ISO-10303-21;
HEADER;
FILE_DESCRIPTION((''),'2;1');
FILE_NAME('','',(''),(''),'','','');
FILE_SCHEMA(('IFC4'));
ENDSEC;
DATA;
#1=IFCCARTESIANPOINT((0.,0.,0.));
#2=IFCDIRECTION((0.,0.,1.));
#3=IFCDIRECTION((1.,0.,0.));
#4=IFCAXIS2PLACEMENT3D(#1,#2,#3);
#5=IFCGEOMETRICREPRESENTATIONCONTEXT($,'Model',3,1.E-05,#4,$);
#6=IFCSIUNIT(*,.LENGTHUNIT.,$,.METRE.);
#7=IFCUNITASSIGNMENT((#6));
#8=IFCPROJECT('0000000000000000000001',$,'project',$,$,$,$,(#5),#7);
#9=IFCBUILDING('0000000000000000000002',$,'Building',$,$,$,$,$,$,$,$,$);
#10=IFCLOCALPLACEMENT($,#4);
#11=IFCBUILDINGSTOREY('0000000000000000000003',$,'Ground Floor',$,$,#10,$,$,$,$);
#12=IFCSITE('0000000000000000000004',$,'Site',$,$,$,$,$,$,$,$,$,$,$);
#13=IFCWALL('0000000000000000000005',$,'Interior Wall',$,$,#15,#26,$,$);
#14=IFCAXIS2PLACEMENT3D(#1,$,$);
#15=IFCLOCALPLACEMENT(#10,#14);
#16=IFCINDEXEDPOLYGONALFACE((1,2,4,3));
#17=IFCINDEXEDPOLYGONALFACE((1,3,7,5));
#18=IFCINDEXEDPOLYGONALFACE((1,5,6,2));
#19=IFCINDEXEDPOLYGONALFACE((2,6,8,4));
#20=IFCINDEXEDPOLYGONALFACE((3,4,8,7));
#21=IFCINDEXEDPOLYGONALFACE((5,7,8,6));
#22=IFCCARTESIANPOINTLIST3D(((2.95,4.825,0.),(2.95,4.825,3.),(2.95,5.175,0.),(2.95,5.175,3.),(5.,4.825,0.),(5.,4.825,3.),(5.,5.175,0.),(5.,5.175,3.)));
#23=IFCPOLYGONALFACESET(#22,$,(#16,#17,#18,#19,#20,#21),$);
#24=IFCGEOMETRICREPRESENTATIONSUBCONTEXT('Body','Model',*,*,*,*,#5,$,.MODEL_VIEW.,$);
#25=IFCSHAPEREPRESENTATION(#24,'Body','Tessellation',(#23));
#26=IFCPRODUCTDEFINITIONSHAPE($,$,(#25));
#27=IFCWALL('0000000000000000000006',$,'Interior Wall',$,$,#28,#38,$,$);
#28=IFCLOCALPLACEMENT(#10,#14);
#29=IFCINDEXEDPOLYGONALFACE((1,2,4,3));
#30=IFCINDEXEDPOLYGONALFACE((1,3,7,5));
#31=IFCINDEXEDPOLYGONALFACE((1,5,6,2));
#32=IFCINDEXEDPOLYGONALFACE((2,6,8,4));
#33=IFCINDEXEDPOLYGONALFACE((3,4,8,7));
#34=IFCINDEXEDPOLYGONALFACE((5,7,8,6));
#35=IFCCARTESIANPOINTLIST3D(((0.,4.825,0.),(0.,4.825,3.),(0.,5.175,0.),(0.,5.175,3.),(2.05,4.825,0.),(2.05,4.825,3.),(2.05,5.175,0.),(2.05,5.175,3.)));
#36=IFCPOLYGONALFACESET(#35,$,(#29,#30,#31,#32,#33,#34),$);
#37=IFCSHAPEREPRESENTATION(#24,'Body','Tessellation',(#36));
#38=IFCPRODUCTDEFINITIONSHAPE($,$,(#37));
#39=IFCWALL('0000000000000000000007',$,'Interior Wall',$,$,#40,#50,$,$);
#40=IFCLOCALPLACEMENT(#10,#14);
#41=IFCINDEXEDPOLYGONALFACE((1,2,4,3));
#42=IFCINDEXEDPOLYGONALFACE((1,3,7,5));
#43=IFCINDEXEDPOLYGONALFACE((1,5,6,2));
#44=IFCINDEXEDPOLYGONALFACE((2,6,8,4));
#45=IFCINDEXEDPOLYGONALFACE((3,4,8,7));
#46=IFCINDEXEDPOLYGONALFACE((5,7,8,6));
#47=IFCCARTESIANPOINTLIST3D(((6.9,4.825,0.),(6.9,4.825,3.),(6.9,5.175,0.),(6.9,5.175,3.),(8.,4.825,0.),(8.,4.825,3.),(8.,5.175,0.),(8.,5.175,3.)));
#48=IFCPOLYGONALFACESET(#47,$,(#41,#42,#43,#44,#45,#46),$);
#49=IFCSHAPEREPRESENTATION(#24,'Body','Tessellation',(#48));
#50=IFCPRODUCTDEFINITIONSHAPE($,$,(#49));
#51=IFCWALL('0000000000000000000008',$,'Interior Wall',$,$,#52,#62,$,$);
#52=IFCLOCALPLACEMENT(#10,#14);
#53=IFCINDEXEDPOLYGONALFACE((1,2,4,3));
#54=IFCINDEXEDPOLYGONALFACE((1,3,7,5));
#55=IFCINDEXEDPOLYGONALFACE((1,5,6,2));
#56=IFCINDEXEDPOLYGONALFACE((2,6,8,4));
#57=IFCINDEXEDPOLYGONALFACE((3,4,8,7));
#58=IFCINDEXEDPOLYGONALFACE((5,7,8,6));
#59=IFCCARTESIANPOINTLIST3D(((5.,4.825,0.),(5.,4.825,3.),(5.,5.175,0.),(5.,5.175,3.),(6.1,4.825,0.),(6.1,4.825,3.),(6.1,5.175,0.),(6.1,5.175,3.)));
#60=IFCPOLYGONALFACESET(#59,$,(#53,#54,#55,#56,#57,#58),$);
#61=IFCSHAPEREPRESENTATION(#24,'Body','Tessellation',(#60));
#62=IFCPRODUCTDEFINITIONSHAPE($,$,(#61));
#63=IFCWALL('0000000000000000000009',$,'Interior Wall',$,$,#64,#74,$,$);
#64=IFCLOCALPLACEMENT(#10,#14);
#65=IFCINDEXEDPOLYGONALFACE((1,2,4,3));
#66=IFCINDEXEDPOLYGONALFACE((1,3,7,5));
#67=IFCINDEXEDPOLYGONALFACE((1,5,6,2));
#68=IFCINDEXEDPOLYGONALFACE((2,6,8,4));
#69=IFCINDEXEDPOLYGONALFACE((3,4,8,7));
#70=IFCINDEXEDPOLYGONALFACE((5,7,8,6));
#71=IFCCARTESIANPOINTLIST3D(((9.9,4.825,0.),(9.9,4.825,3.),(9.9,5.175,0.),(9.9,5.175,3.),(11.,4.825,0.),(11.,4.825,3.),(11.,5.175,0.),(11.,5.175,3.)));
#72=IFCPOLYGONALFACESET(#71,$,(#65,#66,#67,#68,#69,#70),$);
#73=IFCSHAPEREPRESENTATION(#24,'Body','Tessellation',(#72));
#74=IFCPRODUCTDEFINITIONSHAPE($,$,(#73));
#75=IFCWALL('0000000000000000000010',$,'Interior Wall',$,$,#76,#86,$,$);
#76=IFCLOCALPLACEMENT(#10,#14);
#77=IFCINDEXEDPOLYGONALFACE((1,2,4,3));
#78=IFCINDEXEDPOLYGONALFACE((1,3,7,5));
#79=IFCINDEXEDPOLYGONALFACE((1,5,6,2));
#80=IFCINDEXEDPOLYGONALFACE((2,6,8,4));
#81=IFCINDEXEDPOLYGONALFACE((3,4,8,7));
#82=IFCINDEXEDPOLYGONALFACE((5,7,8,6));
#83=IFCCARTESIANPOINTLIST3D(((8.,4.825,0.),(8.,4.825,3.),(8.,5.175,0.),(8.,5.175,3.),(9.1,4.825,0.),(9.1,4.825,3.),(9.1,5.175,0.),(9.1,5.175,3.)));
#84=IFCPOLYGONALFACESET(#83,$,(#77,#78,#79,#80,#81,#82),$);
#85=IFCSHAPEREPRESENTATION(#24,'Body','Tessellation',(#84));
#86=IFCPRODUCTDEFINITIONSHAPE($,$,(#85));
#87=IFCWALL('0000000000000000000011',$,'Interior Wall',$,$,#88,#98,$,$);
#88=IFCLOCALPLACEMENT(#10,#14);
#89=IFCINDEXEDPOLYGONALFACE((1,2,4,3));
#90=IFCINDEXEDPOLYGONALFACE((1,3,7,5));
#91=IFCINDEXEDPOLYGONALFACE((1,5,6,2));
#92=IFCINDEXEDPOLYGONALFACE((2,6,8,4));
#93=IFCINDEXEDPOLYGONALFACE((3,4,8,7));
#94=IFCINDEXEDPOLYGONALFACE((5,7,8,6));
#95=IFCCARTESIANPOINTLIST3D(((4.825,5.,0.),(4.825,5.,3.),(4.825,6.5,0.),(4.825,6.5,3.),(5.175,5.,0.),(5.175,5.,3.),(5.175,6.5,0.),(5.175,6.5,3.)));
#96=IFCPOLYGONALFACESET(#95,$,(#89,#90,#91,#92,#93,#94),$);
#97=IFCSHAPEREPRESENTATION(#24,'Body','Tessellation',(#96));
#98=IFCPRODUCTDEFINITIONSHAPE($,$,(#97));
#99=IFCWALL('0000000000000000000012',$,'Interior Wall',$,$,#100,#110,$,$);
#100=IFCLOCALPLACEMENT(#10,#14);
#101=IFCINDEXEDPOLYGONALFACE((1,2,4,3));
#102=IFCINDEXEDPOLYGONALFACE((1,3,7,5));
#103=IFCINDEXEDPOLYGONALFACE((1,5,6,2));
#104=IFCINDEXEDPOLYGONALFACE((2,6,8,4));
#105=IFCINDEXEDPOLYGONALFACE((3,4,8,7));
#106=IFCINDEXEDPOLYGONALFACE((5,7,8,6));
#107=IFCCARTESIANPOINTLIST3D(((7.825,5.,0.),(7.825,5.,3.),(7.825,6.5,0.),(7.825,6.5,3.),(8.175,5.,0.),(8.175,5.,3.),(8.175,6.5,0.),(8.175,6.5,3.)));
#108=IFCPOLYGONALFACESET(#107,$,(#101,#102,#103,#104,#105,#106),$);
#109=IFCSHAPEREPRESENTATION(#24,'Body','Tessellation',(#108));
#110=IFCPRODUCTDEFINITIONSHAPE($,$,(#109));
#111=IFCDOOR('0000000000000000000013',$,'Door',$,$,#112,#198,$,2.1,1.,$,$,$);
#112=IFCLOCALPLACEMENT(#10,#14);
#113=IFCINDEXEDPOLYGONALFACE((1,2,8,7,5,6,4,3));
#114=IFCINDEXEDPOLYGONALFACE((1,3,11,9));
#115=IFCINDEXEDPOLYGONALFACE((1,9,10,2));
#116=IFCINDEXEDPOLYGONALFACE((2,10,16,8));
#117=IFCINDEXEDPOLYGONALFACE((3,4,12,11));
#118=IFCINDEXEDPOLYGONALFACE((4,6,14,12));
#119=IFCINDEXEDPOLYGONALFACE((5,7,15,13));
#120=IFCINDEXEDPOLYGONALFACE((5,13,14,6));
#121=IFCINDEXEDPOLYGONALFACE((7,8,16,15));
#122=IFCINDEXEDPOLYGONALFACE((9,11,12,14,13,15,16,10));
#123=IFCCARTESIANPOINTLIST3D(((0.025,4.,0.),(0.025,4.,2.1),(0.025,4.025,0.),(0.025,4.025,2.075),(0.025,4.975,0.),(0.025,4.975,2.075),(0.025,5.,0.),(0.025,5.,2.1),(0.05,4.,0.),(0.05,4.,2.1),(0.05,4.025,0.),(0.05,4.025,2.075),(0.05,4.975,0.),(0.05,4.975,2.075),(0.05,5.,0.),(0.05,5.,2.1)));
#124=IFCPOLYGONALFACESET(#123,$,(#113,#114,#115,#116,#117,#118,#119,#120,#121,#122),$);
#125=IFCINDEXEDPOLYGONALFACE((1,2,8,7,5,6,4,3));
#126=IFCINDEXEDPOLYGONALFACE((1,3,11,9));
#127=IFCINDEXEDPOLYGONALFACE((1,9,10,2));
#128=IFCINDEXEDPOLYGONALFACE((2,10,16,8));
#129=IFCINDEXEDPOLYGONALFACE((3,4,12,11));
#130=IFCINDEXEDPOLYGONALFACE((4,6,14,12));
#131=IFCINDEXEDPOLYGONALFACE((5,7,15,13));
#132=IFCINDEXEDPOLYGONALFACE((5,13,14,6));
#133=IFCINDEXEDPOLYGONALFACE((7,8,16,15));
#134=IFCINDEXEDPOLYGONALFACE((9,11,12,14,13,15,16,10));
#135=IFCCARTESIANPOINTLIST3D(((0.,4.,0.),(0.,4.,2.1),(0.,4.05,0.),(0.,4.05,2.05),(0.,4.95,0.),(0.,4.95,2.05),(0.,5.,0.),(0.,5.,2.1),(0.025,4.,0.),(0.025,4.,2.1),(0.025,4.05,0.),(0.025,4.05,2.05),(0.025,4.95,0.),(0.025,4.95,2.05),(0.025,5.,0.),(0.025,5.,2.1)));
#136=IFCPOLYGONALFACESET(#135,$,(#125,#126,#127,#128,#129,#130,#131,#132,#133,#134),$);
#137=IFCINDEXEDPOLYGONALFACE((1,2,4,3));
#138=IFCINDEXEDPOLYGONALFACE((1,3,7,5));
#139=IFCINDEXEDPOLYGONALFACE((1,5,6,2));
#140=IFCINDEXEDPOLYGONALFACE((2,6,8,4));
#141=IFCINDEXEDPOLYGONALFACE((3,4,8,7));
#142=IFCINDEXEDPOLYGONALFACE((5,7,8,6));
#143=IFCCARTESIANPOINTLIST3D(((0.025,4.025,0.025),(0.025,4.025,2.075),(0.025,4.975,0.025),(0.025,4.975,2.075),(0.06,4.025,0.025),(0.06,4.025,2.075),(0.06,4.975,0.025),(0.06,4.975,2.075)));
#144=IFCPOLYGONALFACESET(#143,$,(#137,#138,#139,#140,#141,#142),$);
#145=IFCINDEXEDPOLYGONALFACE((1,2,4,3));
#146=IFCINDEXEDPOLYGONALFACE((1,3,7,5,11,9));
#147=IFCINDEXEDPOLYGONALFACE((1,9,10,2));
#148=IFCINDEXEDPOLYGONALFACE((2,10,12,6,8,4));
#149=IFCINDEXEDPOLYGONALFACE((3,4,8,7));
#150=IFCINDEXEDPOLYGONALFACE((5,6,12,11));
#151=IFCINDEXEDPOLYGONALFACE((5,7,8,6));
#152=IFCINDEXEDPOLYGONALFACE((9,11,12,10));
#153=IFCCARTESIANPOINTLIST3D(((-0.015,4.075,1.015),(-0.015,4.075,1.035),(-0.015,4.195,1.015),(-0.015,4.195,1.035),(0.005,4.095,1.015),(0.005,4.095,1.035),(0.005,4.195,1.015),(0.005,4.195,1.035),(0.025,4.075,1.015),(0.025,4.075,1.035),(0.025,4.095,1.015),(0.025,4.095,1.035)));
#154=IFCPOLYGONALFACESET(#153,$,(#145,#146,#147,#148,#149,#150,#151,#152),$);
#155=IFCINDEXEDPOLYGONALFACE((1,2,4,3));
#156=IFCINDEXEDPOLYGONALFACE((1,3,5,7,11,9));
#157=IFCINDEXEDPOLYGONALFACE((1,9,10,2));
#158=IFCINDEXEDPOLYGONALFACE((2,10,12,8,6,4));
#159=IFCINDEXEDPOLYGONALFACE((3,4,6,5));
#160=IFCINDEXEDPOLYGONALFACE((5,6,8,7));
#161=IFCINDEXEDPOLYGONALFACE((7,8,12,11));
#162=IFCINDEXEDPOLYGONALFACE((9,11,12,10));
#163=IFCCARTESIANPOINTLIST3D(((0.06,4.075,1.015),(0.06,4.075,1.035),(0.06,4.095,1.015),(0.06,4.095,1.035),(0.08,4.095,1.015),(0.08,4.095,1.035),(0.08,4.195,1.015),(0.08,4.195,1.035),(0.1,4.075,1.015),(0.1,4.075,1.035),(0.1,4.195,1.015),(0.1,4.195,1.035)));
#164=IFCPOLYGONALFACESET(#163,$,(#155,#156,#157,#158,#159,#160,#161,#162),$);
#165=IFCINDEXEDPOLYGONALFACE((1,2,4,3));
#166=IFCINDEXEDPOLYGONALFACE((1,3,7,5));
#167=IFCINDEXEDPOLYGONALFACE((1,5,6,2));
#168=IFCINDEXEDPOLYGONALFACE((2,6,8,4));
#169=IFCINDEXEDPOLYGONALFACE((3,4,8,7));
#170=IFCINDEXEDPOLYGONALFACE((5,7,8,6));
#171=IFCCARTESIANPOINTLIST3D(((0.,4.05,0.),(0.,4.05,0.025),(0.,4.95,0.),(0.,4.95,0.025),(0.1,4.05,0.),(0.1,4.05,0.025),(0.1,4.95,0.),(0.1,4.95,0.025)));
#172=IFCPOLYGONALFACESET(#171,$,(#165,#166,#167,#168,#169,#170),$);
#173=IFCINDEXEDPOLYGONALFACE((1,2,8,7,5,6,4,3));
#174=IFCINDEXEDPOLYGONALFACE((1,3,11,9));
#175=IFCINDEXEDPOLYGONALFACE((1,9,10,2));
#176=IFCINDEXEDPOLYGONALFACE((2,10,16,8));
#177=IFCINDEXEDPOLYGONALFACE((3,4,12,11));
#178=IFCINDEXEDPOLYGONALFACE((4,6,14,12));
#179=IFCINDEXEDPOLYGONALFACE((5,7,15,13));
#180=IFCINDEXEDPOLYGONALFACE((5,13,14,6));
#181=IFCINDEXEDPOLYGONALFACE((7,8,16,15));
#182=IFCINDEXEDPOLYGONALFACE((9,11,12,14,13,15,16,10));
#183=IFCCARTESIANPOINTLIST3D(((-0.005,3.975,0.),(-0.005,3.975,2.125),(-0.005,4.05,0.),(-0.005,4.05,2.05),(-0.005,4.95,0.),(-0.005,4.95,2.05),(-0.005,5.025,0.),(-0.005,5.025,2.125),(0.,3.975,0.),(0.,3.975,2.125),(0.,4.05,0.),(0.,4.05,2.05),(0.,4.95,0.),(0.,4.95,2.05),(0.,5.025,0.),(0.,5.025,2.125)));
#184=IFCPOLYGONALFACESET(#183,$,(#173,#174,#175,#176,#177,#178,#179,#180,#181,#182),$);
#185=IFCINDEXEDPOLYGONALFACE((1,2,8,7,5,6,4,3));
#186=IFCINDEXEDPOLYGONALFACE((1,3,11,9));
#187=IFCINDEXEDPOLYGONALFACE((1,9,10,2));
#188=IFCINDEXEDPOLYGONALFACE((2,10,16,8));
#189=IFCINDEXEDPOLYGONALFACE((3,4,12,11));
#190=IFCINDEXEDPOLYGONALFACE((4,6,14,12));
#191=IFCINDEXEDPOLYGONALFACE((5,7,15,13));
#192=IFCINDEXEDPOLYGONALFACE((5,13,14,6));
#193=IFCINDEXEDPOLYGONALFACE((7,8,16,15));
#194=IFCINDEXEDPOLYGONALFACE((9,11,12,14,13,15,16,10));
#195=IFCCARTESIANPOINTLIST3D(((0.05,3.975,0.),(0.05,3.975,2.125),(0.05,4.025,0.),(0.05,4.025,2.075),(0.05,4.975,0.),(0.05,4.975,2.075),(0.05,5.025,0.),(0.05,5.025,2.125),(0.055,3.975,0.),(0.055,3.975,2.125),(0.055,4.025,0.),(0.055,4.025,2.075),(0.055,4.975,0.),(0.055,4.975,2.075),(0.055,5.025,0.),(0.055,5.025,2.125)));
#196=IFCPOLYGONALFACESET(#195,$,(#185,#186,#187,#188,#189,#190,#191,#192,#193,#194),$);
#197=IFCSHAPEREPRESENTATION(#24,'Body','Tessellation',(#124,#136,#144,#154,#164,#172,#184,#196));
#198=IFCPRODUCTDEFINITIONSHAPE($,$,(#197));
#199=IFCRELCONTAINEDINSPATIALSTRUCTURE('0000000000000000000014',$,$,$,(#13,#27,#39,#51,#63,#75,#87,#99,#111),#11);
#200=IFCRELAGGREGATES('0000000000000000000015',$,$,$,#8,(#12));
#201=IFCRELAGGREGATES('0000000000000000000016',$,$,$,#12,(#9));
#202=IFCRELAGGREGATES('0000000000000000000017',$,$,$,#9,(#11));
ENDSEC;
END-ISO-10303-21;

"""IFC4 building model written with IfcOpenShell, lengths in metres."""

from ifc_helpers import new_model, si_unit, frame, origin_with_axes, place, context, subcontext, project, spatial, line, indexed_curve, outline, extrude, element, save


model = new_model("IFC4")

# Units and contexts
model_context = context("Model", 3, precision=1e-05, world=origin_with_axes())
body_context = subcontext(model_context, "Body", "Model", "MODEL_VIEW")
ifc_project = project(units=[si_unit("LENGTHUNIT", "METRE")], contexts=[model_context])

# Site, building, storey
site = spatial("IfcSite", under=ifc_project, Name="Site")
building = spatial("IfcBuilding", under=site, Name="Building")
storey_placement = place(None, origin_with_axes())
storey = spatial("IfcBuildingStorey", under=building, at=storey_placement, Name="Ground Floor")

# Walls
for number, where, z_axis, x_axis, name in (
    (1, (5.0, 5.0, 0.0), (0.0, 0.0, 1.0), (-1.0, 0.0, 0.0), "Interior Wall"),
    (2, (2.05, 5.0, 0.0), (0.0, 0.0, 1.0), (-1.0, 0.0, 0.0), "Interior Wall"),
):
    element("IfcWall", number, at=place(storey_placement, frame(where, z_axis=z_axis, x_axis=x_axis)), inside=storey, Name=name, context=body_context, shape_type="SweptSolid", body=[
        extrude(outline(indexed_curve([(0.0, 0.0), (0.0, 0.35), (2.05, 0.35), (2.05, 0.0), (0.0, 0.0)], self_intersect=False)), frame((0.0, -0.175, 0.0), z_axis=(0.0, 0.0, 1.0), x_axis=(1.0, 0.0, 0.0)), (0.0, 0.0, 1.0), 3.0),
    ])
for number, where, z_axis, x_axis, name in (
    (3, (8.0, 5.0, 0.0), (0.0, 0.0, 1.0), (-1.0, 0.0, 0.0), "Interior Wall"),
    (4, (6.1, 5.0, 0.0), (0.0, 0.0, 1.0), (-1.0, 0.0, 0.0), "Interior Wall"),
    (5, (11.0, 5.0, 0.0), (0.0, 0.0, 1.0), (-1.0, 0.0, 0.0), "Interior Wall"),
    (6, (9.1, 5.0, 0.0), (0.0, 0.0, 1.0), (-1.0, 0.0, 0.0), "Interior Wall"),
):
    element("IfcWall", number, at=place(storey_placement, frame(where, z_axis=z_axis, x_axis=x_axis)), inside=storey, Name=name, context=body_context, shape_type="SweptSolid", body=[
        extrude(outline(indexed_curve([(0.0, 0.0), (0.0, 0.35), (1.1, 0.35), (1.1, 0.0), (0.0, 0.0)], self_intersect=False)), frame((0.0, -0.175, 0.0), z_axis=(0.0, 0.0, 1.0), x_axis=(1.0, 0.0, 0.0)), (0.0, 0.0, 1.0), 3.0),
    ])
for number, where, z_axis, x_axis, name in (
    (7, (5.0, 5.0, 0.0), (0.0, 0.0, 1.0), (0.0, 1.0, 0.0), "Interior Wall"),
    (8, (8.0, 5.0, 0.0), (0.0, 0.0, 1.0), (0.0, 1.0, 0.0), "Interior Wall"),
):
    element("IfcWall", number, at=place(storey_placement, frame(where, z_axis=z_axis, x_axis=x_axis)), inside=storey, Name=name, context=body_context, shape_type="SweptSolid", body=[
        extrude(outline(indexed_curve([(0.0, 0.0), (0.0, 0.35), (1.5, 0.35), (1.5, 0.0), (0.0, 0.0)], self_intersect=False)), frame((0.0, -0.175, 0.0), z_axis=(0.0, 0.0, 1.0), x_axis=(1.0, 0.0, 0.0)), (0.0, 0.0, 1.0), 3.0),
    ])

# Door
door_1_placement = place(storey_placement, frame((0.0, 5.0, 0.0), z_axis=(0.0, 0.0, 1.0), x_axis=(0.0, -1.0, 0.0)))
element("IfcDoor", 9, at=door_1_placement, inside=storey, Name="Door", OverallHeight=2.1, OverallWidth=1.0, context=body_context, shape_type="SweptSolid", body=[
    extrude(outline(indexed_curve([(0.0, 0.0), (0.0, 2.1), (1.0, 2.1), (1.0, 0.0), (0.975, 0.0), (0.975, 2.075), (0.025, 2.075), (0.025, 0.0)], segments=[line(1, 2, 3, 4, 5, 6, 7, 8, 1)])), frame((0.0, 0.025, 0.0), z_axis=(0.0, -1.0, 0.0), x_axis=(1.0, 0.0, 0.0)), (0.0, 0.0, -1.0), 0.025),
    extrude(outline(indexed_curve([(0.0, 0.0), (0.0, 2.1), (1.0, 2.1), (1.0, 0.0), (0.95, 0.0), (0.95, 2.05), (0.05, 2.05), (0.05, 0.0)], segments=[line(1, 2, 3, 4, 5, 6, 7, 8, 1)])), frame((0.0, 0.0, 0.0), z_axis=(0.0, -1.0, 0.0), x_axis=(1.0, 0.0, 0.0)), (0.0, 0.0, -1.0), 0.025),
    extrude(outline(indexed_curve([(0.0, 0.0), (0.95, 0.0), (0.95, 0.035), (0.0, 0.035)], segments=[line(1, 2, 3, 4, 1)])), frame((0.025, 0.025, 0.025), z_axis=(0.0, 0.0, 1.0), x_axis=(1.0, 0.0, 0.0)), (0.0, 0.0, 1.0), 2.05),
    extrude(outline(indexed_curve([(0.0, 0.0), (0.0, -0.04), (-0.12, -0.04), (-0.12, -0.02), (-0.02, -0.02), (-0.02, 0.0)], segments=[line(1, 2, 3, 4, 5, 6, 1)])), frame((0.925, 0.025, 1.015), z_axis=(0.0, 0.0, 1.0), x_axis=(1.0, 0.0, 0.0)), (0.0, 0.0, 1.0), 0.02),
    extrude(outline(indexed_curve([(0.0, 0.0), (0.0, 0.04), (-0.12, 0.04), (-0.12, 0.02), (-0.02, 0.02), (-0.02, 0.0)], segments=[line(1, 2, 3, 4, 5, 6, 1)])), frame((0.925, 0.06, 1.015), z_axis=(0.0, 0.0, 1.0), x_axis=(1.0, 0.0, 0.0)), (0.0, 0.0, 1.0), 0.02),
    extrude(outline(indexed_curve([(0.0, 0.0), (0.9, 0.0), (0.9, 0.1), (0.0, 0.1)], segments=[line(1, 2, 3, 4, 1)])), frame((0.05, 0.0, 0.0), z_axis=(0.0, 0.0, 1.0), x_axis=(1.0, 0.0, 0.0)), (0.0, 0.0, 1.0), 0.025),
    extrude(outline(indexed_curve([(0.0, 0.0), (0.0, 2.125), (1.05, 2.125), (1.05, 0.0), (0.975, 0.0), (0.975, 2.05), (0.075, 2.05), (0.075, 0.0)], segments=[line(1, 2, 3, 4, 5, 6, 7, 8, 1)])), frame((-0.025, -0.005, 0.0), z_axis=(0.0, -1.0, 0.0), x_axis=(1.0, 0.0, 0.0)), (0.0, 0.0, -1.0), 0.005),
    extrude(outline(indexed_curve([(0.0, 0.0), (0.0, 2.125), (1.05, 2.125), (1.05, 0.0), (1.0, 0.0), (1.0, 2.075), (0.05, 2.075), (0.05, 0.0)], segments=[line(1, 2, 3, 4, 5, 6, 7, 8, 1)])), frame((-0.025, 0.05, 0.0), z_axis=(0.0, -1.0, 0.0), x_axis=(1.0, 0.0, 0.0)), (0.0, 0.0, -1.0), 0.005),
])

save(model, "model.ifc")
